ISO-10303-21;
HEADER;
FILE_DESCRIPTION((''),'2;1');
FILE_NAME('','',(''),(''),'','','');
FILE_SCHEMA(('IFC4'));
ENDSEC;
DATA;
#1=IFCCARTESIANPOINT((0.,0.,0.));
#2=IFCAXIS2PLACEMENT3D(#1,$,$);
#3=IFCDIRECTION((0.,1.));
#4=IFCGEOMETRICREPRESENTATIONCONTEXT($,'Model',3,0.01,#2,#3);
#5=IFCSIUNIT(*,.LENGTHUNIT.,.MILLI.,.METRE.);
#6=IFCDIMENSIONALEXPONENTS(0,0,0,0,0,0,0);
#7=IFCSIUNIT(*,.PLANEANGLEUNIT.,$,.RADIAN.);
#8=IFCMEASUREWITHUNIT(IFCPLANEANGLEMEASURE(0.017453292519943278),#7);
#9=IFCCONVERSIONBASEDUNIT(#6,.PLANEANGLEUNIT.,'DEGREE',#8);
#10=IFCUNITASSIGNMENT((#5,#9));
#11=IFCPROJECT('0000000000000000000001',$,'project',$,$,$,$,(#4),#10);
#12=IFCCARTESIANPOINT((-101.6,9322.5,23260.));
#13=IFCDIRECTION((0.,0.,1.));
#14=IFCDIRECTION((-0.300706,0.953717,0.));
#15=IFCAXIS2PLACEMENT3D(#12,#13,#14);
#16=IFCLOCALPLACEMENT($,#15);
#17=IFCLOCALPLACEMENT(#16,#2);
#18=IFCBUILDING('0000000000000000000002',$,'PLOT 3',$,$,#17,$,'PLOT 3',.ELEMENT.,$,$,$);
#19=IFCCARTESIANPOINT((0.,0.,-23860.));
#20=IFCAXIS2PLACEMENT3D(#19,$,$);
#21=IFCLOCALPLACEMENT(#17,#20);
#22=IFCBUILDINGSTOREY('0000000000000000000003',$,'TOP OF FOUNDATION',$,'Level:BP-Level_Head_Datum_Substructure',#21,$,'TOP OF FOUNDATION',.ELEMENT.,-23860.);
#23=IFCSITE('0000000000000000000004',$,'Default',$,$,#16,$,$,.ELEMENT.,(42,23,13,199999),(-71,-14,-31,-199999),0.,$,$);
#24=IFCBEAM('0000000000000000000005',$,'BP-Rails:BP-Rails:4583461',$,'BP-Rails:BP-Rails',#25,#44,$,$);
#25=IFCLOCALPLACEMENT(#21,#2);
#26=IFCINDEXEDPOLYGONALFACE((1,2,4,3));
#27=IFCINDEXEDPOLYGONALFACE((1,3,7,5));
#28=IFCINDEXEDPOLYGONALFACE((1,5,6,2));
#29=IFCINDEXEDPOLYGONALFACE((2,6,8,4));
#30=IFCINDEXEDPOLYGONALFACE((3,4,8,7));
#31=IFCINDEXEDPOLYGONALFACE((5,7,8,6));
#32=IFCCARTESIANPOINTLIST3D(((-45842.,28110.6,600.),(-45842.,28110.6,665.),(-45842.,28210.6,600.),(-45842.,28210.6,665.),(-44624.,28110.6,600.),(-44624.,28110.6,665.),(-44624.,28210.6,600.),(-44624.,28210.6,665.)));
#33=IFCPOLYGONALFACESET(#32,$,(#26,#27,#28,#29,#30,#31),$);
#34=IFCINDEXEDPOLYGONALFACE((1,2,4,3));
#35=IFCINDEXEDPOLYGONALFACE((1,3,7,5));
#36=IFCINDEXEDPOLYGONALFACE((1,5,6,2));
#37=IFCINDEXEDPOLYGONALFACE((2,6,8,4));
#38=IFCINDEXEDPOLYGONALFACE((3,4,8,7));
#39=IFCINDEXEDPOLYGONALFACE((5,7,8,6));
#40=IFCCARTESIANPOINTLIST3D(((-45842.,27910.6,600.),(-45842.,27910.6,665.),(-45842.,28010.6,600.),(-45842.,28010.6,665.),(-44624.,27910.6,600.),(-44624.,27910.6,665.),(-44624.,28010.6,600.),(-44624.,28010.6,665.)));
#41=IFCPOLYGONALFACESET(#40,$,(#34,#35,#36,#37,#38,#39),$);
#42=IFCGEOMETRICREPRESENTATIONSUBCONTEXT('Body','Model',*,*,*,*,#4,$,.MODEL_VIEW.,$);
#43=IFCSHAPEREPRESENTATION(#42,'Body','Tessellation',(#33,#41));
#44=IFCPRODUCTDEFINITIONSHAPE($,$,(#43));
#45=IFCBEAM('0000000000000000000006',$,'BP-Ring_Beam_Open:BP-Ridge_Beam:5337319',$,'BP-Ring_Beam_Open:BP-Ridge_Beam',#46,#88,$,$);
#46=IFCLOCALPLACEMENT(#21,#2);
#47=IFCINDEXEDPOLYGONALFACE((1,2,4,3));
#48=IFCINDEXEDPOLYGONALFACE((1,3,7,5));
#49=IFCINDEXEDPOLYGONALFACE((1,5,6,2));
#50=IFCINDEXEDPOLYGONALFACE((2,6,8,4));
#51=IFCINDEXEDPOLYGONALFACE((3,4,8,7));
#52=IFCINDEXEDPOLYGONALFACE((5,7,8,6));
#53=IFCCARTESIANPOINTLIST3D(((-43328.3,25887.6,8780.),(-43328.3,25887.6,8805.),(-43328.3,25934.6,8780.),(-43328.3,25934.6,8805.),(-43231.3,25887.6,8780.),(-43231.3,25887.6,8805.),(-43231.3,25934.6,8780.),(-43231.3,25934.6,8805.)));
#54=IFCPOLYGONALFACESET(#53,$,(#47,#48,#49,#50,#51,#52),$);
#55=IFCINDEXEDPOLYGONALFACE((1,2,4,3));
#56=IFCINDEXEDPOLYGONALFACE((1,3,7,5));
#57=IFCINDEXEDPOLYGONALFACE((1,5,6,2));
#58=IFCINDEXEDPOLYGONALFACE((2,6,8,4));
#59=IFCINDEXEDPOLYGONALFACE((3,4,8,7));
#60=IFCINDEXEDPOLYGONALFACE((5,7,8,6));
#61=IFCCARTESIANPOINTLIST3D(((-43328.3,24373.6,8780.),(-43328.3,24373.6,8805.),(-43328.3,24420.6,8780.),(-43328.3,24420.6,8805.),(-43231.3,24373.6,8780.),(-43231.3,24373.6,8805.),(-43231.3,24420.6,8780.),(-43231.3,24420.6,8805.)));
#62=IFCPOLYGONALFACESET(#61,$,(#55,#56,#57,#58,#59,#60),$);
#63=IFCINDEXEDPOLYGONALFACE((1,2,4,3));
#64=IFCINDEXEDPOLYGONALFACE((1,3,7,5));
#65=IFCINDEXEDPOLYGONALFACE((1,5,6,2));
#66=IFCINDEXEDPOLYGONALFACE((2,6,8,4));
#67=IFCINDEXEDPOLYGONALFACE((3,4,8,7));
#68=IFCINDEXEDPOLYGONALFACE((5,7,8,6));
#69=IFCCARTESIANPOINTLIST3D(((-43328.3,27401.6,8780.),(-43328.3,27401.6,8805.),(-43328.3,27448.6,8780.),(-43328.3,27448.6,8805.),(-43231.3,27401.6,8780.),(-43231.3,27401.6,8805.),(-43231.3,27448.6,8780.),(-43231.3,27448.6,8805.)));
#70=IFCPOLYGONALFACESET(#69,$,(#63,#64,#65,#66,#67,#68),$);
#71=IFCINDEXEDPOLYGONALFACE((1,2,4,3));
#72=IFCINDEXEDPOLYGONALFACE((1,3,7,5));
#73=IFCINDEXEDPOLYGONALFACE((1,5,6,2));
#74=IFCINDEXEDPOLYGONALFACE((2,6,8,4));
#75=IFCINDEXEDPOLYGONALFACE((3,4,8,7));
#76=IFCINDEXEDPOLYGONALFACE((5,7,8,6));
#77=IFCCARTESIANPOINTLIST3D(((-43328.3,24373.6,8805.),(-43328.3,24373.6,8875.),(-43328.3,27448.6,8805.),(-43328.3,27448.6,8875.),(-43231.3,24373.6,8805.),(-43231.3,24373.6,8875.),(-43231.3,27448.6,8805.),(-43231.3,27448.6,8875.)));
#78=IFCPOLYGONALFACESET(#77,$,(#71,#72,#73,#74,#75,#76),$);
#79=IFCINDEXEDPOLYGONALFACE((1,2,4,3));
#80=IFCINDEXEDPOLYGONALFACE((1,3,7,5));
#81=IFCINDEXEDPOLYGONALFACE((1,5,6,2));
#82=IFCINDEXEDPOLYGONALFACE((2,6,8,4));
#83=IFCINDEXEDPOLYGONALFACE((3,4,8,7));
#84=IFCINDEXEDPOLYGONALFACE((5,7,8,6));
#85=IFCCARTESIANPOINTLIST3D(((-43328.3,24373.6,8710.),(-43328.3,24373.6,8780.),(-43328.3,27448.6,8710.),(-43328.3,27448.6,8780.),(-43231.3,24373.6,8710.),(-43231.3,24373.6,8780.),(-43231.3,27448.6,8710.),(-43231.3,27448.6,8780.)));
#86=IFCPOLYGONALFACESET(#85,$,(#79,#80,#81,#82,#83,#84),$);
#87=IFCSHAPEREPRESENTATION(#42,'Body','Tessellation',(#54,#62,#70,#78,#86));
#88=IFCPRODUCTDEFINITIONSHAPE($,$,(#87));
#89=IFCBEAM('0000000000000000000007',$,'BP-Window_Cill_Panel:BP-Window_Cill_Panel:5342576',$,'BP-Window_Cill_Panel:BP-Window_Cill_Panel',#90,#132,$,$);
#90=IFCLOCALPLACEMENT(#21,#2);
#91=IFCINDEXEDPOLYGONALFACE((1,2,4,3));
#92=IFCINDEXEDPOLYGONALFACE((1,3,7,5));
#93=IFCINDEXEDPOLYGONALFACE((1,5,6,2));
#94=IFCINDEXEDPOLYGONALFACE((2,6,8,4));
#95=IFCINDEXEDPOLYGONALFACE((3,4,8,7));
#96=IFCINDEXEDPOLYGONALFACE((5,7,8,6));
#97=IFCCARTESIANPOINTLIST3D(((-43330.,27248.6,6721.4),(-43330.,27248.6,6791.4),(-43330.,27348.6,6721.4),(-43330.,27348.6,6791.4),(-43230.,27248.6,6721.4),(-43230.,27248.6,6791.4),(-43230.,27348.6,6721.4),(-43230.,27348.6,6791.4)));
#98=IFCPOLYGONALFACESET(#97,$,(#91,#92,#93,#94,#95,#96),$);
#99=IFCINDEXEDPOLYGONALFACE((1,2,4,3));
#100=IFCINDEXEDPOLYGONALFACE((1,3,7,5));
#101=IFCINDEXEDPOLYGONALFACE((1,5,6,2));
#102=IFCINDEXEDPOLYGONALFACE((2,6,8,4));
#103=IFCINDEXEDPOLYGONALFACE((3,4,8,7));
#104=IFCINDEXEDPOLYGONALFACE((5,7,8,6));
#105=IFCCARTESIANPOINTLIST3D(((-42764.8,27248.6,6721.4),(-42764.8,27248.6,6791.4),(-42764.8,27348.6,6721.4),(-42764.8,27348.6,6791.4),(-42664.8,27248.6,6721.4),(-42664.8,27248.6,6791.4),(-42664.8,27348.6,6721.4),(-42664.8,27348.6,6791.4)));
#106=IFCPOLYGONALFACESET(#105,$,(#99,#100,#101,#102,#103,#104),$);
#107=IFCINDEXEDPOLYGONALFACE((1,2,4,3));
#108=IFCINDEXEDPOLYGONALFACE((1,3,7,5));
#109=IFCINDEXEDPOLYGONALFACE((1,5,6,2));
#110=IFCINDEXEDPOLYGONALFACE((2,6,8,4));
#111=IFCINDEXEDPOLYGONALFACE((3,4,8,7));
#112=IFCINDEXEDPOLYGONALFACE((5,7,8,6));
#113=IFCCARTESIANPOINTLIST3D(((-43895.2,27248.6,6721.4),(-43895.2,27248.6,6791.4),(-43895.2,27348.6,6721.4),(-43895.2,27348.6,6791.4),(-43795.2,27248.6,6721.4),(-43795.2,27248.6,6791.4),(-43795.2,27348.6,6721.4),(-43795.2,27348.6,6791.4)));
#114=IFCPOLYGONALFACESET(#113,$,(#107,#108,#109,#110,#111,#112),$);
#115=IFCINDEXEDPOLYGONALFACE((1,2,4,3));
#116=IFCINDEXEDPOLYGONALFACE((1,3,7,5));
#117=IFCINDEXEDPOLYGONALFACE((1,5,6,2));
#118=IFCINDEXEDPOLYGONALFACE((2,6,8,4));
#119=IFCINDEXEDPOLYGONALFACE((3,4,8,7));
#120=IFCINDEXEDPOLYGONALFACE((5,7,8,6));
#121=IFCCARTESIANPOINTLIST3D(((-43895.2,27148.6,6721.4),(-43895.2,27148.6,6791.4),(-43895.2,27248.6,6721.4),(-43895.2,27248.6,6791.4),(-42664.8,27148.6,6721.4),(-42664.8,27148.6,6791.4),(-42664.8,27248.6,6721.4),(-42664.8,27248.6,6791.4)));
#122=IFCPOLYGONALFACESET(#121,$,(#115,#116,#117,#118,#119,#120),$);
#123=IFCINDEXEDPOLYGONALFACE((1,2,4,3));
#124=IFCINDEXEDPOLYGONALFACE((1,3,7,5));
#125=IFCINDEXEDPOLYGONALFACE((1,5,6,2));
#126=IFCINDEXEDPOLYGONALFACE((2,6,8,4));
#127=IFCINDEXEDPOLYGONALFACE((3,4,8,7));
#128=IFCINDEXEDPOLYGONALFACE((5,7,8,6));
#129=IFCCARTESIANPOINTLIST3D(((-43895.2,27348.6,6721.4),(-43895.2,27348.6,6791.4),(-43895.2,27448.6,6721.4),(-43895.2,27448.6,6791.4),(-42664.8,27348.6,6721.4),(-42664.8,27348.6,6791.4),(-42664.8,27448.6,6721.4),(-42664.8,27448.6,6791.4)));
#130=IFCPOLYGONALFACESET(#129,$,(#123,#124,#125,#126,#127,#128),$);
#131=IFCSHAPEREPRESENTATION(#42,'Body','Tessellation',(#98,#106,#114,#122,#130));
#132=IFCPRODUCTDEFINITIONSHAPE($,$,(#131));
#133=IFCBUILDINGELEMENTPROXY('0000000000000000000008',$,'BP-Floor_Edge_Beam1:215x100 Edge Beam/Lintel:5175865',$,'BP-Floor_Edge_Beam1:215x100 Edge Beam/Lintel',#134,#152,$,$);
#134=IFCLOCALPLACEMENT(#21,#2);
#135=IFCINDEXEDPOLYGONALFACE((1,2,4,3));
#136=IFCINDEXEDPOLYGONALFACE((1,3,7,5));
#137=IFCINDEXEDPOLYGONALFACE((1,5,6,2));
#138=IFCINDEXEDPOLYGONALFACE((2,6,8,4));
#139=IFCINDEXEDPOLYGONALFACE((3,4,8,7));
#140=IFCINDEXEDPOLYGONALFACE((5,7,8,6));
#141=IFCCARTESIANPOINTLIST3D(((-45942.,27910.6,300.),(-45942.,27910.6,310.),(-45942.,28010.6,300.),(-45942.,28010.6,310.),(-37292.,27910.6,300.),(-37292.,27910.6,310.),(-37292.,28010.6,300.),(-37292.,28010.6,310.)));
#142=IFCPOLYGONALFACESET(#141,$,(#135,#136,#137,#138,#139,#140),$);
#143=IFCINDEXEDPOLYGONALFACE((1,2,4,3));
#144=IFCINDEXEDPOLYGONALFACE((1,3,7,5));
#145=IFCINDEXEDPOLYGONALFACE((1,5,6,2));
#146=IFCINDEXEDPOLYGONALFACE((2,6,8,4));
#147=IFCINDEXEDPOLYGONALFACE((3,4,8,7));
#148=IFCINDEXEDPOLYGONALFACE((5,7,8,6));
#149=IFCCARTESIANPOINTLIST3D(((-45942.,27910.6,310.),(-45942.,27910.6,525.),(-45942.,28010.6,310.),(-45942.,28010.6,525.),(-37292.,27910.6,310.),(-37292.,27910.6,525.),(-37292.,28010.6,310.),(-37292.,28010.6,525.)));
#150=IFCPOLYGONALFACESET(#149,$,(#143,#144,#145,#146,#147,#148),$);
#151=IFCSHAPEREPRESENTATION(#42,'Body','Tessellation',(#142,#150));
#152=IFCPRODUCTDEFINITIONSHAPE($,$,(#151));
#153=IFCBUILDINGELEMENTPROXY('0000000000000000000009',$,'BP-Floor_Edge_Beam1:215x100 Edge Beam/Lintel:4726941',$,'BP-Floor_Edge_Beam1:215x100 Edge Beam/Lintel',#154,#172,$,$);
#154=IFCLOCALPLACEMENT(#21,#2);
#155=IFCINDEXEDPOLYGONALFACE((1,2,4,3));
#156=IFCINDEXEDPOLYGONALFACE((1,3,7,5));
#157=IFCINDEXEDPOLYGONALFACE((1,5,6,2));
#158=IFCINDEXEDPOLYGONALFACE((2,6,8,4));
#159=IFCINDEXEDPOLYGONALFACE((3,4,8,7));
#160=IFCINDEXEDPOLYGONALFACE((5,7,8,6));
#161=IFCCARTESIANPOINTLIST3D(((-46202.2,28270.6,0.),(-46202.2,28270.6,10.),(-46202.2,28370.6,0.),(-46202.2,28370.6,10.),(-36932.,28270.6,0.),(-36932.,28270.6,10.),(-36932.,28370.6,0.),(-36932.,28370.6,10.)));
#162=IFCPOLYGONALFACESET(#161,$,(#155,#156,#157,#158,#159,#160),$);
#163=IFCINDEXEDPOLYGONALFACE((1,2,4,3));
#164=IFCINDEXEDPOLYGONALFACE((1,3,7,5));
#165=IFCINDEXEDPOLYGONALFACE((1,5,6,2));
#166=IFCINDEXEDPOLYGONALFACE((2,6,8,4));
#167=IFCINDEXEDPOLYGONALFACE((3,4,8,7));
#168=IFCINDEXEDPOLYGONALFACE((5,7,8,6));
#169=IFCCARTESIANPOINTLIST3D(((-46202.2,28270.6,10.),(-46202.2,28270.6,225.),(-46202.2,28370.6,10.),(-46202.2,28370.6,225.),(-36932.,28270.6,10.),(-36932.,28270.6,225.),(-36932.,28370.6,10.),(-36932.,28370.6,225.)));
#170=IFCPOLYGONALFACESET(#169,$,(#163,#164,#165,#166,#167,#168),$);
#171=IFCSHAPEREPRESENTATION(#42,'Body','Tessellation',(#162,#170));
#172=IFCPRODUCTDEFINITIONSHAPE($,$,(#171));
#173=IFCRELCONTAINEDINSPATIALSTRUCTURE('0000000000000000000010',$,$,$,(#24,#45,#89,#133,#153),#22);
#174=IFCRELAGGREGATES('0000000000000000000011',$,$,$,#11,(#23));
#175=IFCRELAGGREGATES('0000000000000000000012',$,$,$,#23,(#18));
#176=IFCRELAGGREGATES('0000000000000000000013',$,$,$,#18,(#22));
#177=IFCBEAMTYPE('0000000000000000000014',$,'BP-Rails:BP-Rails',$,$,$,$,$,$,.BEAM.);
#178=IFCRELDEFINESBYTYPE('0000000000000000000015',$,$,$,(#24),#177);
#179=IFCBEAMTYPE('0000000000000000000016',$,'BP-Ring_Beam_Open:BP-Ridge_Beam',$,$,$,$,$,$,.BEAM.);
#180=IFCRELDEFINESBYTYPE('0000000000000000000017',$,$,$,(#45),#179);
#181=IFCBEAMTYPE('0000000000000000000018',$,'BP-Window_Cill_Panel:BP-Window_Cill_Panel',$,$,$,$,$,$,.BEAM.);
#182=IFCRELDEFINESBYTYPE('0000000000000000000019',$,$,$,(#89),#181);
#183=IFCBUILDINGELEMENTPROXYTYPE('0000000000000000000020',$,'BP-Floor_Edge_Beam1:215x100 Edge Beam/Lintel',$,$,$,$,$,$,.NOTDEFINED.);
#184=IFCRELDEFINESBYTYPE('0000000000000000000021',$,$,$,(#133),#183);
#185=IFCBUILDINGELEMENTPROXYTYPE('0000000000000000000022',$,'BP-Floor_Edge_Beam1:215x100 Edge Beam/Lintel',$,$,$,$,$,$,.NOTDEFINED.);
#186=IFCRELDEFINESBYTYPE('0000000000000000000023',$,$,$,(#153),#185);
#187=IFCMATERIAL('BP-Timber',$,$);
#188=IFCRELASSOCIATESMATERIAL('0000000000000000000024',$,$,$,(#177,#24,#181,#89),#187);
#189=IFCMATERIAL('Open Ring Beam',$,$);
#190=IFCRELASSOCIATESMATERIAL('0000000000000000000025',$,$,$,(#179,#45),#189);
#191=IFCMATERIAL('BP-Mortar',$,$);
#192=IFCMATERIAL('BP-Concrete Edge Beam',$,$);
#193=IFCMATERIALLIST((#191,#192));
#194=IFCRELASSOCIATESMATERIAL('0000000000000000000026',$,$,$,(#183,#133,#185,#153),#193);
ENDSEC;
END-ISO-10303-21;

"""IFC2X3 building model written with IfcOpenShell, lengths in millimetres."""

from ifc_helpers import new_model, entity, si_unit, converted_unit, direction, frame, frame_2d, origin, origin_2d_with_axis, place, context, subcontext, project, spatial, rectangle, extrude, source, transform, mapped, material, material_list, type_object, type_shapes, element, save


model = new_model("IFC2X3")

# Units and contexts
model_context = context("Model", 3, precision=0.01, world=origin(), true_north=direction((0.0, 1.0)))
body_context = subcontext(model_context, "Body", "Model", "MODEL_VIEW")
ifc_project = project(units=[si_unit("LENGTHUNIT", "METRE", prefix="MILLI"), converted_unit("PLANEANGLEUNIT", "DEGREE", entity("IfcPlaneAngleMeasure", 0.017453292519943278), si_unit("PLANEANGLEUNIT", "RADIAN"), dimensions=[0, 0, 0, 0, 0, 0, 0])], contexts=[model_context])

# Site, building, storey
site_placement = place(None, frame((-101.6, 9322.5, 23260.0), z_axis=(0.0, 0.0, 1.0), x_axis=(-0.300706, 0.953717, 0.0)))
site = spatial("IfcSite", under=ifc_project, at=site_placement, Name="Default", CompositionType="ELEMENT", RefLatitude=(42, 23, 13, 199999), RefLongitude=(-71, -14, -31, -199999), RefElevation=0.0)
building_placement = place(site_placement, origin())
building = spatial("IfcBuilding", under=site, at=building_placement, Name="PLOT 3", LongName="PLOT 3", CompositionType="ELEMENT")
storey_placement = place(building_placement, frame((0.0, 0.0, -23860.0)))
storey = spatial("IfcBuildingStorey", under=building, at=storey_placement, Name="TOP OF FOUNDATION", ObjectType="Level:BP-Level_Head_Datum_Substructure", LongName="TOP OF FOUNDATION", CompositionType="ELEMENT", Elevation=-23860.0)

# Beams
ifc_material_1 = material(Name="BP-Timber")
beam_type_1 = type_object("IfcBeamType", Name="BP-Rails:BP-Rails", PredefinedType="BEAM", material=ifc_material_1)
shared_shape_1 = source(origin(), body_context, "Body", "SweptSolid", [
    extrude(rectangle(XDim=65.0, YDim=100.0, at=frame_2d((0.0, 0.0), x_axis=(1.0, 0.0))), frame((-609.0, 100.0, -32.5), z_axis=(1.0, 0.0, 0.0), x_axis=(0.0, 0.0, -1.0)), (0.0, 0.0, 1.0), 1218.0),
    extrude(rectangle(XDim=65.0, YDim=100.0, at=origin_2d_with_axis()), frame((-609.0, -100.0, -32.5), z_axis=(1.0, 0.0, 0.0), x_axis=(0.0, 0.0, -1.0)), (0.0, 0.0, 1.0), 1218.0),
])
type_shapes(beam_type_1, [shared_shape_1])
beam_1_placement = place(storey_placement, frame((-45233.0, 28060.6, 665.0)))
element("IfcBeam", 1, at=beam_1_placement, inside=storey, type_object=beam_type_1, material=ifc_material_1, Name="BP-Rails:BP-Rails:4583461", ObjectType="BP-Rails:BP-Rails", context=body_context, shape_type="MappedRepresentation", body=[
    mapped(shared_shape_1, transform((0.0, 0.0, 0.0), scale=1.0)),
])
ifc_material_2 = material(Name="Open Ring Beam")
beam_type_2 = type_object("IfcBeamType", Name="BP-Ring_Beam_Open:BP-Ridge_Beam", PredefinedType="BEAM", material=ifc_material_2)
shared_shape_2 = source(origin(), body_context, "Body", "SweptSolid", [
    extrude(rectangle(XDim=25.0, YDim=97.0, at=frame_2d((0.0, 0.0), x_axis=(1.0, 0.0))), frame((-23.5, 0.0, -82.5), z_axis=(1.0, 0.0, 0.0), x_axis=(0.0, 0.0, -1.0)), (0.0, 0.0, 1.0), 47.0),
    extrude(rectangle(XDim=25.0, YDim=97.0, at=frame_2d((0.0, 0.0), x_axis=(1.0, 0.0))), frame((1490.5, 0.0, -82.5), z_axis=(1.0, 0.0, 0.0), x_axis=(0.0, 0.0, -1.0)), (0.0, 0.0, 1.0), 47.0),
    extrude(rectangle(XDim=25.0, YDim=97.0, at=frame_2d((0.0, 0.0), x_axis=(1.0, 0.0))), frame((-1537.5, 0.0, -82.5), z_axis=(1.0, 0.0, 0.0), x_axis=(0.0, 0.0, -1.0)), (0.0, 0.0, 1.0), 47.0),
    extrude(rectangle(XDim=70.0, YDim=97.0, at=origin_2d_with_axis()), frame((-1537.5, 0.0, -35.0), z_axis=(1.0, 0.0, 0.0), x_axis=(0.0, 0.0, -1.0)), (0.0, 0.0, 1.0), 3075.0),
    extrude(rectangle(XDim=70.0, YDim=97.0, at=origin_2d_with_axis()), frame((-1537.5, 0.0, -130.0), z_axis=(1.0, 0.0, 0.0), x_axis=(0.0, 0.0, -1.0)), (0.0, 0.0, 1.0), 3075.0),
])
type_shapes(beam_type_2, [shared_shape_2])
beam_2_placement = place(storey_placement, frame((-43279.8, 25911.1, 8875.0), z_axis=(0.0, 0.0, 1.0), x_axis=(0.0, -1.0, 0.0)))
element("IfcBeam", 2, at=beam_2_placement, inside=storey, type_object=beam_type_2, material=ifc_material_2, Name="BP-Ring_Beam_Open:BP-Ridge_Beam:5337319", ObjectType="BP-Ring_Beam_Open:BP-Ridge_Beam", context=body_context, shape_type="MappedRepresentation", body=[
    mapped(shared_shape_2, transform((0.0, 0.0, 0.0), scale=1.0)),
])
beam_type_3 = type_object("IfcBeamType", Name="BP-Window_Cill_Panel:BP-Window_Cill_Panel", PredefinedType="BEAM", material=ifc_material_1)
shared_shape_3 = source(origin(), body_context, "Body", "SweptSolid", [
    extrude(rectangle(XDim=70.0, YDim=100.0, at=frame_2d((0.0, 0.0), x_axis=(1.0, 0.0))), frame((-50.0, 0.0, -35.0), z_axis=(1.0, 0.0, 0.0), x_axis=(0.0, 0.0, -1.0)), (0.0, 0.0, 1.0), 100.0),
    extrude(rectangle(XDim=70.0, YDim=100.0, at=frame_2d((0.0, 0.0), x_axis=(1.0, 0.0))), frame((515.2, 0.0, -35.0), z_axis=(1.0, 0.0, 0.0), x_axis=(0.0, 0.0, -1.0)), (0.0, 0.0, 1.0), 100.0),
    extrude(rectangle(XDim=70.0, YDim=100.0, at=frame_2d((0.0, 0.0), x_axis=(1.0, 0.0))), frame((-615.2, 0.0, -35.0), z_axis=(1.0, 0.0, 0.0), x_axis=(0.0, 0.0, -1.0)), (0.0, 0.0, 1.0), 100.0),
    extrude(rectangle(XDim=70.0, YDim=100.0, at=frame_2d((0.0, 0.0), x_axis=(1.0, 0.0))), frame((-615.2, -100.0, -35.0), z_axis=(1.0, 0.0, 0.0), x_axis=(0.0, 0.0, -1.0)), (0.0, 0.0, 1.0), 1230.4),
    extrude(rectangle(XDim=70.0, YDim=100.0, at=origin_2d_with_axis()), frame((-615.2, 100.0, -35.0), z_axis=(1.0, 0.0, 0.0), x_axis=(0.0, 0.0, -1.0)), (0.0, 0.0, 1.0), 1230.4),
])
type_shapes(beam_type_3, [shared_shape_3])
beam_3_placement = place(storey_placement, frame((-43280.0, 27298.6, 6791.4)))
element("IfcBeam", 3, at=beam_3_placement, inside=storey, type_object=beam_type_3, material=ifc_material_1, Name="BP-Window_Cill_Panel:BP-Window_Cill_Panel:5342576", ObjectType="BP-Window_Cill_Panel:BP-Window_Cill_Panel", context=body_context, shape_type="MappedRepresentation", body=[
    mapped(shared_shape_3, transform((0.0, 0.0, 0.0), scale=1.0)),
])

# Building element proxies
ifc_material_3 = material(Name="BP-Mortar")
ifc_material_4 = material(Name="BP-Concrete Edge Beam")
ifc_material_list = material_list([ifc_material_3, ifc_material_4])
building_element_proxy_type_1 = type_object("IfcBuildingElementProxyType", Name="BP-Floor_Edge_Beam1:215x100 Edge Beam/Lintel", PredefinedType="NOTDEFINED", material=ifc_material_list)
shared_shape_4 = source(origin(), body_context, "Body", "SweptSolid", [
    extrude(rectangle(XDim=100.0, YDim=8650.0, at=frame_2d((0.0, 0.0), x_axis=(1.0, 0.0))), frame((0.0, 0.0, 0.0), z_axis=(0.0, 0.0, 1.0), x_axis=(0.0, 1.0, 0.0)), (0.0, 0.0, 1.0), 10.0),
    extrude(rectangle(XDim=100.0, YDim=8650.0, at=origin_2d_with_axis()), frame((0.0, 0.0, 10.0), z_axis=(0.0, 0.0, 1.0), x_axis=(0.0, 1.0, 0.0)), (0.0, 0.0, 1.0), 215.0),
])
type_shapes(building_element_proxy_type_1, [shared_shape_4])
proxy_1_placement = place(storey_placement, frame((-41617.0, 27960.6, 300.0), z_axis=(0.0, 0.0, 1.0), x_axis=(-1.0, 0.0, 0.0)))
element("IfcBuildingElementProxy", 4, at=proxy_1_placement, inside=storey, type_object=building_element_proxy_type_1, material=ifc_material_list, Name="BP-Floor_Edge_Beam1:215x100 Edge Beam/Lintel:5175865", ObjectType="BP-Floor_Edge_Beam1:215x100 Edge Beam/Lintel", context=body_context, shape_type="MappedRepresentation", body=[
    mapped(shared_shape_4, transform((0.0, 0.0, 0.0), scale=1.0)),
])
building_element_proxy_type_2 = type_object("IfcBuildingElementProxyType", Name="BP-Floor_Edge_Beam1:215x100 Edge Beam/Lintel", PredefinedType="NOTDEFINED", material=ifc_material_list)
shared_shape_5 = source(origin(), body_context, "Body", "SweptSolid", [
    extrude(rectangle(XDim=100.0, YDim=9270.2, at=frame_2d((0.0, 0.0), x_axis=(1.0, 0.0))), frame((0.0, 0.0, 0.0), z_axis=(0.0, 0.0, 1.0), x_axis=(0.0, 1.0, 0.0)), (0.0, 0.0, 1.0), 10.0),
    extrude(rectangle(XDim=100.0, YDim=9270.2, at=origin_2d_with_axis()), frame((0.0, 0.0, 10.0), z_axis=(0.0, 0.0, 1.0), x_axis=(0.0, 1.0, 0.0)), (0.0, 0.0, 1.0), 215.0),
])
type_shapes(building_element_proxy_type_2, [shared_shape_5])
proxy_2_placement = place(storey_placement, frame((-41567.1, 28320.6, 0.0), z_axis=(0.0, 0.0, 1.0), x_axis=(-1.0, 0.0, 0.0)))
element("IfcBuildingElementProxy", 5, at=proxy_2_placement, inside=storey, type_object=building_element_proxy_type_2, material=ifc_material_list, Name="BP-Floor_Edge_Beam1:215x100 Edge Beam/Lintel:4726941", ObjectType="BP-Floor_Edge_Beam1:215x100 Edge Beam/Lintel", context=body_context, shape_type="MappedRepresentation", body=[
    mapped(shared_shape_5, transform((0.0, 0.0, 0.0), scale=1.0)),
])

save(model, "model.ifc")
